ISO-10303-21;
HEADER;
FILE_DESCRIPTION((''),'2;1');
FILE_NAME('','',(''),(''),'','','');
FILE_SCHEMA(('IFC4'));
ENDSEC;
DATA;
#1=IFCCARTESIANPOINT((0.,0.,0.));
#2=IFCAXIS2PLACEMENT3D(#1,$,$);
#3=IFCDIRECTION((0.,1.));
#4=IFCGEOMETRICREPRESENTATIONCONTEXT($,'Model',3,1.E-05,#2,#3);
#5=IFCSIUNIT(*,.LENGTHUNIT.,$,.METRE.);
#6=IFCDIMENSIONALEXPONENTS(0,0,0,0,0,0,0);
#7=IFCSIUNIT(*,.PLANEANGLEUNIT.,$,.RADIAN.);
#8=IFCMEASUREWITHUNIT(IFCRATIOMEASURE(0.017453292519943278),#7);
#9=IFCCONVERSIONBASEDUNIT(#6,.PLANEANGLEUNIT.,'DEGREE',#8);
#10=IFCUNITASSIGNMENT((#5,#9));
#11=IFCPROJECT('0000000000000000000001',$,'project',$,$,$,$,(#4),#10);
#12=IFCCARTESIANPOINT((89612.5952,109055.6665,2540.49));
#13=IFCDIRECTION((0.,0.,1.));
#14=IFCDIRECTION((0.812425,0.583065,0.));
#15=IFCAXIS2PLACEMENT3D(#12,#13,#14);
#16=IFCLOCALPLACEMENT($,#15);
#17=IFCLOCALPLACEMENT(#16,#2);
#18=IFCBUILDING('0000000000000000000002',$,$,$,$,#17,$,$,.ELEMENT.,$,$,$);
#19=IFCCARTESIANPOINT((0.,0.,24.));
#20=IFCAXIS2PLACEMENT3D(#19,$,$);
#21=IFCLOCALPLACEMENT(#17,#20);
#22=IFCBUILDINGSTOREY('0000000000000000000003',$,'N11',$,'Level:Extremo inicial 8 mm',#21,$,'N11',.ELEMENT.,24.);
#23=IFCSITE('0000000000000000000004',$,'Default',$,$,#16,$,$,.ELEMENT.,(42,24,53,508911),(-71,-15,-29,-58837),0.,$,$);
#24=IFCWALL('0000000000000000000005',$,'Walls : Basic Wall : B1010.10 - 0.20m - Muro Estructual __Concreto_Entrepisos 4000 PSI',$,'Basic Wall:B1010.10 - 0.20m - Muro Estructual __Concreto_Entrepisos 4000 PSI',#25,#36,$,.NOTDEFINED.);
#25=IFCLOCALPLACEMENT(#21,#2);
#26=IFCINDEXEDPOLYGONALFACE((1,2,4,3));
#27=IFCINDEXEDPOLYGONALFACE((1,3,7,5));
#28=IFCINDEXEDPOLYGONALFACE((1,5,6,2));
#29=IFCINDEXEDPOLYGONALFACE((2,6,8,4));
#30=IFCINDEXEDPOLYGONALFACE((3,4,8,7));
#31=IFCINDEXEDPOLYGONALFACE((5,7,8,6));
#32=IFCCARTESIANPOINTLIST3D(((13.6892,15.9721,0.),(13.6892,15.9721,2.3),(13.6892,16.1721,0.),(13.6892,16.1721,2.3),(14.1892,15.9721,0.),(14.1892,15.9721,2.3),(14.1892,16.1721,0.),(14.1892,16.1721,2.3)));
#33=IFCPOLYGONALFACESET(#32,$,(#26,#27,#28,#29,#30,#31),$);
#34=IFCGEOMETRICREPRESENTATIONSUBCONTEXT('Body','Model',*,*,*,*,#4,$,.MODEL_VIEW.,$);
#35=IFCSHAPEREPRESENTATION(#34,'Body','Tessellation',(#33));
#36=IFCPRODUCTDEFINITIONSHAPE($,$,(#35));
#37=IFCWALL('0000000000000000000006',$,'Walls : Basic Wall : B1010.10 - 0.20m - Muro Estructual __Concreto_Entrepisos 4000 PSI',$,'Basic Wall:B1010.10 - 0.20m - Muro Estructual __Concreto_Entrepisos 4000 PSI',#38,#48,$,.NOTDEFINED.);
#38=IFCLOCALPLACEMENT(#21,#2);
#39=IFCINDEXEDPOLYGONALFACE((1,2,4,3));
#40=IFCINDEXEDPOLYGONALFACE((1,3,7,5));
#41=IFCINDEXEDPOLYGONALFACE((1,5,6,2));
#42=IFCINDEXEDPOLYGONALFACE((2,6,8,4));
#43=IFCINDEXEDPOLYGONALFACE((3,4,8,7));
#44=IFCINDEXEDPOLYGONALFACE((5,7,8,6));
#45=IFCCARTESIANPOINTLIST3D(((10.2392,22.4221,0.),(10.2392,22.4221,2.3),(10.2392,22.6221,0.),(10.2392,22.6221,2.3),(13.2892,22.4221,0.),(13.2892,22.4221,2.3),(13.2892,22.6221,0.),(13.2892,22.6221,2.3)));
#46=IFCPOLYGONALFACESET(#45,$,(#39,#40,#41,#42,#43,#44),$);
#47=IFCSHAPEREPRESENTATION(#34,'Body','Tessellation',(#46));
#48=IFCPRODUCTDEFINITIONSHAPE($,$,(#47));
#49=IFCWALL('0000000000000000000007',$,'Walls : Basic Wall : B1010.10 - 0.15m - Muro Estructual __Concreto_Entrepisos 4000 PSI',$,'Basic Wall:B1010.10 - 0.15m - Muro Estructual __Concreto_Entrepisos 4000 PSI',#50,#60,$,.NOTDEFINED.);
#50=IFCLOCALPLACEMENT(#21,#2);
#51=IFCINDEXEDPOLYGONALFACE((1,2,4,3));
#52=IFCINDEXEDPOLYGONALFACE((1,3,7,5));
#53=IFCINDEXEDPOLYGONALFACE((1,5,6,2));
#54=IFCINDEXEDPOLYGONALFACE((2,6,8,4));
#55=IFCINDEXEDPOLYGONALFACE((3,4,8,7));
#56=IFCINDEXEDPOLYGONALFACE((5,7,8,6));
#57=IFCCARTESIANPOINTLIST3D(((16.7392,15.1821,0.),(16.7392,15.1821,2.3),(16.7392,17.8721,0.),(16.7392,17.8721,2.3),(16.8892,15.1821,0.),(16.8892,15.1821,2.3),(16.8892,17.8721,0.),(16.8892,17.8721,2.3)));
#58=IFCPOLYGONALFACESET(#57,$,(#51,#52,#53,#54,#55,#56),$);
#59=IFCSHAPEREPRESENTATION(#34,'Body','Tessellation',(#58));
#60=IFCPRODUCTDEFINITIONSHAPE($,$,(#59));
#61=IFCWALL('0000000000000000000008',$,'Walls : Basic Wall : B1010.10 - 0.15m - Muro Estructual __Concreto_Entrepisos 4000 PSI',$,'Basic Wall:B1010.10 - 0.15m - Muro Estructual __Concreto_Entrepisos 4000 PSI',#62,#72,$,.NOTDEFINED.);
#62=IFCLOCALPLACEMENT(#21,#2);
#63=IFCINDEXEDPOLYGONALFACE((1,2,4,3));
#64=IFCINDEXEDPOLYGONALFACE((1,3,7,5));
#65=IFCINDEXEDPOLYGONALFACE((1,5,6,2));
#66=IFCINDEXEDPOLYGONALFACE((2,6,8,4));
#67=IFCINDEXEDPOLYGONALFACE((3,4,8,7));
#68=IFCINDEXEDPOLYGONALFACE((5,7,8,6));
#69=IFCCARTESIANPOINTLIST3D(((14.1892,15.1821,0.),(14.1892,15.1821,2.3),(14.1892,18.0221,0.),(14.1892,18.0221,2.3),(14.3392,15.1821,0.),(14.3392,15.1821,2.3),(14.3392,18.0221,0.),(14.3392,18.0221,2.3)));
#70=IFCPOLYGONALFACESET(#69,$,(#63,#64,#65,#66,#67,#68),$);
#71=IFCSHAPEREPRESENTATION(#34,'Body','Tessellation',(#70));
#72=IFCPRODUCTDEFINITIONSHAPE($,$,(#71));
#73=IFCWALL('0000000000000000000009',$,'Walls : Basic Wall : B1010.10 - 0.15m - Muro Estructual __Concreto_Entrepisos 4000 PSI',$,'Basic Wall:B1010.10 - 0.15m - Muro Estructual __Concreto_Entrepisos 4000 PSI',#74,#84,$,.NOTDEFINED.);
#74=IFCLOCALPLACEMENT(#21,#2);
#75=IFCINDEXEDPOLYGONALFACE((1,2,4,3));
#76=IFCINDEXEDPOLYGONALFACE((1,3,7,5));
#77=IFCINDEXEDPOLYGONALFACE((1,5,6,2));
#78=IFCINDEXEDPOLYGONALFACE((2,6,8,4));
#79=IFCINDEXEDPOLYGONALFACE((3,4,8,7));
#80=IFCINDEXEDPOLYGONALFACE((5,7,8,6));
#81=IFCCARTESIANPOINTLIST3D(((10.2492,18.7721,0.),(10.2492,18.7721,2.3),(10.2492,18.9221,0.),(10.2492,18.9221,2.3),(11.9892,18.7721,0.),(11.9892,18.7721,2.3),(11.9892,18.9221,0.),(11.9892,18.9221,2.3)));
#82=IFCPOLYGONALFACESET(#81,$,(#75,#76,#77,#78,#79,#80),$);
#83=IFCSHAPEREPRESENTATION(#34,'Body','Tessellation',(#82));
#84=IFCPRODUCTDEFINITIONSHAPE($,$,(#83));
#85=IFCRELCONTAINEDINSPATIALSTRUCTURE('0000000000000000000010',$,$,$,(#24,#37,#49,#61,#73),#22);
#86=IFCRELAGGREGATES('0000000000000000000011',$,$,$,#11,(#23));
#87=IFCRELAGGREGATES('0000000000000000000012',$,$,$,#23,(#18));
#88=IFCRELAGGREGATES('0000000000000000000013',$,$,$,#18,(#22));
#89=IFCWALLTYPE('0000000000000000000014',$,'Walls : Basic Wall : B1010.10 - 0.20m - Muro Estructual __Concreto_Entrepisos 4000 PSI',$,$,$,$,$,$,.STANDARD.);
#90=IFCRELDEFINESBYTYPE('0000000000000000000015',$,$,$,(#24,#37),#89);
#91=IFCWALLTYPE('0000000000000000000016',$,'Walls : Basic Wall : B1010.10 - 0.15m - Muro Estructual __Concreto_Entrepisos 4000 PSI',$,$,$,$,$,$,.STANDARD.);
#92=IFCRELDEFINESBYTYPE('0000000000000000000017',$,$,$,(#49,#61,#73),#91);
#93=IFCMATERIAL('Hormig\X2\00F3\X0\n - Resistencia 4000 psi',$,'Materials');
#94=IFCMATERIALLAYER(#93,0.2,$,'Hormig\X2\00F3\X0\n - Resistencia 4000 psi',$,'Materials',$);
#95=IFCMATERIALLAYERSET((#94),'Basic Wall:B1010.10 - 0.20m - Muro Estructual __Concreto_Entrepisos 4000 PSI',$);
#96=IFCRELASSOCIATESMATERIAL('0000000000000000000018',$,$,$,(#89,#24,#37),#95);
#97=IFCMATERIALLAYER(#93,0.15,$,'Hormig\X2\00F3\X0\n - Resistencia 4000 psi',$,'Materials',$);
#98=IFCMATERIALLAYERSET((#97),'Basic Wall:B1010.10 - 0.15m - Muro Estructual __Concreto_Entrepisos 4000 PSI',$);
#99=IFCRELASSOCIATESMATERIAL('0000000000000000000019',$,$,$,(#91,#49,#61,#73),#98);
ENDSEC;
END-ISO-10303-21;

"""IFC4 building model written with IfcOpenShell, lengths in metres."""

from ifc_helpers import new_model, entity, si_unit, converted_unit, direction, frame, frame_2d, origin, place, context, subcontext, project, spatial, rectangle, extrude, material, layer, layer_set, layer_usage, type_object, element, save


model = new_model("IFC4")

# Units and contexts
model_context = context("Model", 3, precision=1e-05, world=origin(), true_north=direction((0.0, 1.0)))
body_context = subcontext(model_context, "Body", "Model", "MODEL_VIEW")
ifc_project = project(units=[si_unit("LENGTHUNIT", "METRE"), converted_unit("PLANEANGLEUNIT", "DEGREE", entity("IfcRatioMeasure", 0.017453292519943278), si_unit("PLANEANGLEUNIT", "RADIAN"), dimensions=[0, 0, 0, 0, 0, 0, 0])], contexts=[model_context])

# Site, building, storey
site_placement = place(None, frame((89612.5952, 109055.6665, 2540.49), z_axis=(0.0, 0.0, 1.0), x_axis=(0.812425, 0.583065, 0.0)))
site = spatial("IfcSite", under=ifc_project, at=site_placement, Name="Default", CompositionType="ELEMENT", RefLatitude=(42, 24, 53, 508911), RefLongitude=(-71, -15, -29, -58837), RefElevation=0.0)
building_placement = place(site_placement, origin())
building = spatial("IfcBuilding", under=site, at=building_placement, CompositionType="ELEMENT")
storey_placement = place(building_placement, frame((0.0, 0.0, 24.0)))
storey = spatial("IfcBuildingStorey", under=building, at=storey_placement, Name="N11", ObjectType="Level:Extremo inicial 8 mm", LongName="N11", CompositionType="ELEMENT", Elevation=24.0)

# Walls
ifc_material_1 = material(Name="Hormigón - Resistencia 4000 psi", Category="Materials")
ifc_layer_1 = layer(ifc_material_1, 0.2, Name="Hormigón - Resistencia 4000 psi", Category="Materials")
ifc_layer_set_1 = layer_set([ifc_layer_1], Name="Basic Wall:B1010.10 - 0.20m - Muro Estructual __Concreto_Entrepisos 4000 PSI")
wall_type_1 = type_object("IfcWallType", Name="Walls : Basic Wall : B1010.10 - 0.20m - Muro Estructual __Concreto_Entrepisos 4000 PSI", PredefinedType="STANDARD", material=ifc_layer_set_1)
ifc_layer_usage_1 = layer_usage(ifc_layer_set_1, "AXIS2", "NEGATIVE", 0.1)
wall_1_placement = place(storey_placement, frame((13.6892, 16.0721, 0.0)))
element("IfcWall", 1, at=wall_1_placement, inside=storey, type_object=wall_type_1, material=ifc_layer_usage_1, Name="Walls : Basic Wall : B1010.10 - 0.20m - Muro Estructual __Concreto_Entrepisos 4000 PSI", ObjectType="Basic Wall:B1010.10 - 0.20m - Muro Estructual __Concreto_Entrepisos 4000 PSI", PredefinedType="NOTDEFINED", context=body_context, shape_type="SweptSolid", body=[
    extrude(rectangle(XDim=0.5, YDim=0.2, at=frame_2d((0.25, 0.0), x_axis=(-1.0, 0.0))), origin(), (0.0, 0.0, 1.0), 2.3),
])
ifc_layer_usage_2 = layer_usage(ifc_layer_set_1, "AXIS2", "POSITIVE", -0.1)
wall_2_placement = place(storey_placement, frame((10.2392, 22.5221, 0.0)))
element("IfcWall", 2, at=wall_2_placement, inside=storey, type_object=wall_type_1, material=ifc_layer_usage_2, Name="Walls : Basic Wall : B1010.10 - 0.20m - Muro Estructual __Concreto_Entrepisos 4000 PSI", ObjectType="Basic Wall:B1010.10 - 0.20m - Muro Estructual __Concreto_Entrepisos 4000 PSI", PredefinedType="NOTDEFINED", context=body_context, shape_type="SweptSolid", body=[
    extrude(rectangle(XDim=3.05, YDim=0.2, at=frame_2d((1.525, 0.0), x_axis=(-1.0, 0.0))), origin(), (0.0, 0.0, 1.0), 2.3),
])
ifc_layer_2 = layer(ifc_material_1, 0.15, Name="Hormigón - Resistencia 4000 psi", Category="Materials")
ifc_layer_set_2 = layer_set([ifc_layer_2], Name="Basic Wall:B1010.10 - 0.15m - Muro Estructual __Concreto_Entrepisos 4000 PSI")
ifc_layer_usage_3 = layer_usage(ifc_layer_set_2, "AXIS2", "NEGATIVE", 0.075)
wall_type_2 = type_object("IfcWallType", Name="Walls : Basic Wall : B1010.10 - 0.15m - Muro Estructual __Concreto_Entrepisos 4000 PSI", PredefinedType="STANDARD", material=ifc_layer_set_2)
wall_3_placement = place(storey_placement, frame((16.8142, 15.1821, 0.0), z_axis=(0.0, 0.0, 1.0), x_axis=(0.0, 1.0, 0.0)))
element("IfcWall", 3, at=wall_3_placement, inside=storey, type_object=wall_type_2, material=ifc_layer_usage_3, Name="Walls : Basic Wall : B1010.10 - 0.15m - Muro Estructual __Concreto_Entrepisos 4000 PSI", ObjectType="Basic Wall:B1010.10 - 0.15m - Muro Estructual __Concreto_Entrepisos 4000 PSI", PredefinedType="NOTDEFINED", context=body_context, shape_type="SweptSolid", body=[
    extrude(rectangle(XDim=2.69, YDim=0.15, at=frame_2d((1.345, 0.0), x_axis=(-1.0, 0.0))), origin(), (0.0, 0.0, 1.0), 2.3),
])
ifc_layer_usage_4 = layer_usage(ifc_layer_set_2, "AXIS2", "NEGATIVE", 0.075)
wall_4_placement = place(storey_placement, frame((14.2642, 15.1821, 0.0), z_axis=(0.0, 0.0, 1.0), x_axis=(0.0, 1.0, 0.0)))
element("IfcWall", 4, at=wall_4_placement, inside=storey, type_object=wall_type_2, material=ifc_layer_usage_4, Name="Walls : Basic Wall : B1010.10 - 0.15m - Muro Estructual __Concreto_Entrepisos 4000 PSI", ObjectType="Basic Wall:B1010.10 - 0.15m - Muro Estructual __Concreto_Entrepisos 4000 PSI", PredefinedType="NOTDEFINED", context=body_context, shape_type="SweptSolid", body=[
    extrude(rectangle(XDim=2.84, YDim=0.15, at=frame_2d((1.42, 0.0), x_axis=(-1.0, 0.0))), origin(), (0.0, 0.0, 1.0), 2.3),
])
ifc_layer_usage_5 = layer_usage(ifc_layer_set_2, "AXIS2", "NEGATIVE", 0.075)
wall_5_placement = place(storey_placement, frame((11.9892, 18.8471, 0.0), z_axis=(0.0, 0.0, 1.0), x_axis=(-1.0, 0.0, 0.0)))
element("IfcWall", 5, at=wall_5_placement, inside=storey, type_object=wall_type_2, material=ifc_layer_usage_5, Name="Walls : Basic Wall : B1010.10 - 0.15m - Muro Estructual __Concreto_Entrepisos 4000 PSI", ObjectType="Basic Wall:B1010.10 - 0.15m - Muro Estructual __Concreto_Entrepisos 4000 PSI", PredefinedType="NOTDEFINED", context=body_context, shape_type="SweptSolid", body=[
    extrude(rectangle(XDim=1.74, YDim=0.15, at=frame_2d((0.87, 0.0), x_axis=(-1.0, 0.0))), origin(), (0.0, 0.0, 1.0), 2.3),
])

save(model, "model.ifc")
